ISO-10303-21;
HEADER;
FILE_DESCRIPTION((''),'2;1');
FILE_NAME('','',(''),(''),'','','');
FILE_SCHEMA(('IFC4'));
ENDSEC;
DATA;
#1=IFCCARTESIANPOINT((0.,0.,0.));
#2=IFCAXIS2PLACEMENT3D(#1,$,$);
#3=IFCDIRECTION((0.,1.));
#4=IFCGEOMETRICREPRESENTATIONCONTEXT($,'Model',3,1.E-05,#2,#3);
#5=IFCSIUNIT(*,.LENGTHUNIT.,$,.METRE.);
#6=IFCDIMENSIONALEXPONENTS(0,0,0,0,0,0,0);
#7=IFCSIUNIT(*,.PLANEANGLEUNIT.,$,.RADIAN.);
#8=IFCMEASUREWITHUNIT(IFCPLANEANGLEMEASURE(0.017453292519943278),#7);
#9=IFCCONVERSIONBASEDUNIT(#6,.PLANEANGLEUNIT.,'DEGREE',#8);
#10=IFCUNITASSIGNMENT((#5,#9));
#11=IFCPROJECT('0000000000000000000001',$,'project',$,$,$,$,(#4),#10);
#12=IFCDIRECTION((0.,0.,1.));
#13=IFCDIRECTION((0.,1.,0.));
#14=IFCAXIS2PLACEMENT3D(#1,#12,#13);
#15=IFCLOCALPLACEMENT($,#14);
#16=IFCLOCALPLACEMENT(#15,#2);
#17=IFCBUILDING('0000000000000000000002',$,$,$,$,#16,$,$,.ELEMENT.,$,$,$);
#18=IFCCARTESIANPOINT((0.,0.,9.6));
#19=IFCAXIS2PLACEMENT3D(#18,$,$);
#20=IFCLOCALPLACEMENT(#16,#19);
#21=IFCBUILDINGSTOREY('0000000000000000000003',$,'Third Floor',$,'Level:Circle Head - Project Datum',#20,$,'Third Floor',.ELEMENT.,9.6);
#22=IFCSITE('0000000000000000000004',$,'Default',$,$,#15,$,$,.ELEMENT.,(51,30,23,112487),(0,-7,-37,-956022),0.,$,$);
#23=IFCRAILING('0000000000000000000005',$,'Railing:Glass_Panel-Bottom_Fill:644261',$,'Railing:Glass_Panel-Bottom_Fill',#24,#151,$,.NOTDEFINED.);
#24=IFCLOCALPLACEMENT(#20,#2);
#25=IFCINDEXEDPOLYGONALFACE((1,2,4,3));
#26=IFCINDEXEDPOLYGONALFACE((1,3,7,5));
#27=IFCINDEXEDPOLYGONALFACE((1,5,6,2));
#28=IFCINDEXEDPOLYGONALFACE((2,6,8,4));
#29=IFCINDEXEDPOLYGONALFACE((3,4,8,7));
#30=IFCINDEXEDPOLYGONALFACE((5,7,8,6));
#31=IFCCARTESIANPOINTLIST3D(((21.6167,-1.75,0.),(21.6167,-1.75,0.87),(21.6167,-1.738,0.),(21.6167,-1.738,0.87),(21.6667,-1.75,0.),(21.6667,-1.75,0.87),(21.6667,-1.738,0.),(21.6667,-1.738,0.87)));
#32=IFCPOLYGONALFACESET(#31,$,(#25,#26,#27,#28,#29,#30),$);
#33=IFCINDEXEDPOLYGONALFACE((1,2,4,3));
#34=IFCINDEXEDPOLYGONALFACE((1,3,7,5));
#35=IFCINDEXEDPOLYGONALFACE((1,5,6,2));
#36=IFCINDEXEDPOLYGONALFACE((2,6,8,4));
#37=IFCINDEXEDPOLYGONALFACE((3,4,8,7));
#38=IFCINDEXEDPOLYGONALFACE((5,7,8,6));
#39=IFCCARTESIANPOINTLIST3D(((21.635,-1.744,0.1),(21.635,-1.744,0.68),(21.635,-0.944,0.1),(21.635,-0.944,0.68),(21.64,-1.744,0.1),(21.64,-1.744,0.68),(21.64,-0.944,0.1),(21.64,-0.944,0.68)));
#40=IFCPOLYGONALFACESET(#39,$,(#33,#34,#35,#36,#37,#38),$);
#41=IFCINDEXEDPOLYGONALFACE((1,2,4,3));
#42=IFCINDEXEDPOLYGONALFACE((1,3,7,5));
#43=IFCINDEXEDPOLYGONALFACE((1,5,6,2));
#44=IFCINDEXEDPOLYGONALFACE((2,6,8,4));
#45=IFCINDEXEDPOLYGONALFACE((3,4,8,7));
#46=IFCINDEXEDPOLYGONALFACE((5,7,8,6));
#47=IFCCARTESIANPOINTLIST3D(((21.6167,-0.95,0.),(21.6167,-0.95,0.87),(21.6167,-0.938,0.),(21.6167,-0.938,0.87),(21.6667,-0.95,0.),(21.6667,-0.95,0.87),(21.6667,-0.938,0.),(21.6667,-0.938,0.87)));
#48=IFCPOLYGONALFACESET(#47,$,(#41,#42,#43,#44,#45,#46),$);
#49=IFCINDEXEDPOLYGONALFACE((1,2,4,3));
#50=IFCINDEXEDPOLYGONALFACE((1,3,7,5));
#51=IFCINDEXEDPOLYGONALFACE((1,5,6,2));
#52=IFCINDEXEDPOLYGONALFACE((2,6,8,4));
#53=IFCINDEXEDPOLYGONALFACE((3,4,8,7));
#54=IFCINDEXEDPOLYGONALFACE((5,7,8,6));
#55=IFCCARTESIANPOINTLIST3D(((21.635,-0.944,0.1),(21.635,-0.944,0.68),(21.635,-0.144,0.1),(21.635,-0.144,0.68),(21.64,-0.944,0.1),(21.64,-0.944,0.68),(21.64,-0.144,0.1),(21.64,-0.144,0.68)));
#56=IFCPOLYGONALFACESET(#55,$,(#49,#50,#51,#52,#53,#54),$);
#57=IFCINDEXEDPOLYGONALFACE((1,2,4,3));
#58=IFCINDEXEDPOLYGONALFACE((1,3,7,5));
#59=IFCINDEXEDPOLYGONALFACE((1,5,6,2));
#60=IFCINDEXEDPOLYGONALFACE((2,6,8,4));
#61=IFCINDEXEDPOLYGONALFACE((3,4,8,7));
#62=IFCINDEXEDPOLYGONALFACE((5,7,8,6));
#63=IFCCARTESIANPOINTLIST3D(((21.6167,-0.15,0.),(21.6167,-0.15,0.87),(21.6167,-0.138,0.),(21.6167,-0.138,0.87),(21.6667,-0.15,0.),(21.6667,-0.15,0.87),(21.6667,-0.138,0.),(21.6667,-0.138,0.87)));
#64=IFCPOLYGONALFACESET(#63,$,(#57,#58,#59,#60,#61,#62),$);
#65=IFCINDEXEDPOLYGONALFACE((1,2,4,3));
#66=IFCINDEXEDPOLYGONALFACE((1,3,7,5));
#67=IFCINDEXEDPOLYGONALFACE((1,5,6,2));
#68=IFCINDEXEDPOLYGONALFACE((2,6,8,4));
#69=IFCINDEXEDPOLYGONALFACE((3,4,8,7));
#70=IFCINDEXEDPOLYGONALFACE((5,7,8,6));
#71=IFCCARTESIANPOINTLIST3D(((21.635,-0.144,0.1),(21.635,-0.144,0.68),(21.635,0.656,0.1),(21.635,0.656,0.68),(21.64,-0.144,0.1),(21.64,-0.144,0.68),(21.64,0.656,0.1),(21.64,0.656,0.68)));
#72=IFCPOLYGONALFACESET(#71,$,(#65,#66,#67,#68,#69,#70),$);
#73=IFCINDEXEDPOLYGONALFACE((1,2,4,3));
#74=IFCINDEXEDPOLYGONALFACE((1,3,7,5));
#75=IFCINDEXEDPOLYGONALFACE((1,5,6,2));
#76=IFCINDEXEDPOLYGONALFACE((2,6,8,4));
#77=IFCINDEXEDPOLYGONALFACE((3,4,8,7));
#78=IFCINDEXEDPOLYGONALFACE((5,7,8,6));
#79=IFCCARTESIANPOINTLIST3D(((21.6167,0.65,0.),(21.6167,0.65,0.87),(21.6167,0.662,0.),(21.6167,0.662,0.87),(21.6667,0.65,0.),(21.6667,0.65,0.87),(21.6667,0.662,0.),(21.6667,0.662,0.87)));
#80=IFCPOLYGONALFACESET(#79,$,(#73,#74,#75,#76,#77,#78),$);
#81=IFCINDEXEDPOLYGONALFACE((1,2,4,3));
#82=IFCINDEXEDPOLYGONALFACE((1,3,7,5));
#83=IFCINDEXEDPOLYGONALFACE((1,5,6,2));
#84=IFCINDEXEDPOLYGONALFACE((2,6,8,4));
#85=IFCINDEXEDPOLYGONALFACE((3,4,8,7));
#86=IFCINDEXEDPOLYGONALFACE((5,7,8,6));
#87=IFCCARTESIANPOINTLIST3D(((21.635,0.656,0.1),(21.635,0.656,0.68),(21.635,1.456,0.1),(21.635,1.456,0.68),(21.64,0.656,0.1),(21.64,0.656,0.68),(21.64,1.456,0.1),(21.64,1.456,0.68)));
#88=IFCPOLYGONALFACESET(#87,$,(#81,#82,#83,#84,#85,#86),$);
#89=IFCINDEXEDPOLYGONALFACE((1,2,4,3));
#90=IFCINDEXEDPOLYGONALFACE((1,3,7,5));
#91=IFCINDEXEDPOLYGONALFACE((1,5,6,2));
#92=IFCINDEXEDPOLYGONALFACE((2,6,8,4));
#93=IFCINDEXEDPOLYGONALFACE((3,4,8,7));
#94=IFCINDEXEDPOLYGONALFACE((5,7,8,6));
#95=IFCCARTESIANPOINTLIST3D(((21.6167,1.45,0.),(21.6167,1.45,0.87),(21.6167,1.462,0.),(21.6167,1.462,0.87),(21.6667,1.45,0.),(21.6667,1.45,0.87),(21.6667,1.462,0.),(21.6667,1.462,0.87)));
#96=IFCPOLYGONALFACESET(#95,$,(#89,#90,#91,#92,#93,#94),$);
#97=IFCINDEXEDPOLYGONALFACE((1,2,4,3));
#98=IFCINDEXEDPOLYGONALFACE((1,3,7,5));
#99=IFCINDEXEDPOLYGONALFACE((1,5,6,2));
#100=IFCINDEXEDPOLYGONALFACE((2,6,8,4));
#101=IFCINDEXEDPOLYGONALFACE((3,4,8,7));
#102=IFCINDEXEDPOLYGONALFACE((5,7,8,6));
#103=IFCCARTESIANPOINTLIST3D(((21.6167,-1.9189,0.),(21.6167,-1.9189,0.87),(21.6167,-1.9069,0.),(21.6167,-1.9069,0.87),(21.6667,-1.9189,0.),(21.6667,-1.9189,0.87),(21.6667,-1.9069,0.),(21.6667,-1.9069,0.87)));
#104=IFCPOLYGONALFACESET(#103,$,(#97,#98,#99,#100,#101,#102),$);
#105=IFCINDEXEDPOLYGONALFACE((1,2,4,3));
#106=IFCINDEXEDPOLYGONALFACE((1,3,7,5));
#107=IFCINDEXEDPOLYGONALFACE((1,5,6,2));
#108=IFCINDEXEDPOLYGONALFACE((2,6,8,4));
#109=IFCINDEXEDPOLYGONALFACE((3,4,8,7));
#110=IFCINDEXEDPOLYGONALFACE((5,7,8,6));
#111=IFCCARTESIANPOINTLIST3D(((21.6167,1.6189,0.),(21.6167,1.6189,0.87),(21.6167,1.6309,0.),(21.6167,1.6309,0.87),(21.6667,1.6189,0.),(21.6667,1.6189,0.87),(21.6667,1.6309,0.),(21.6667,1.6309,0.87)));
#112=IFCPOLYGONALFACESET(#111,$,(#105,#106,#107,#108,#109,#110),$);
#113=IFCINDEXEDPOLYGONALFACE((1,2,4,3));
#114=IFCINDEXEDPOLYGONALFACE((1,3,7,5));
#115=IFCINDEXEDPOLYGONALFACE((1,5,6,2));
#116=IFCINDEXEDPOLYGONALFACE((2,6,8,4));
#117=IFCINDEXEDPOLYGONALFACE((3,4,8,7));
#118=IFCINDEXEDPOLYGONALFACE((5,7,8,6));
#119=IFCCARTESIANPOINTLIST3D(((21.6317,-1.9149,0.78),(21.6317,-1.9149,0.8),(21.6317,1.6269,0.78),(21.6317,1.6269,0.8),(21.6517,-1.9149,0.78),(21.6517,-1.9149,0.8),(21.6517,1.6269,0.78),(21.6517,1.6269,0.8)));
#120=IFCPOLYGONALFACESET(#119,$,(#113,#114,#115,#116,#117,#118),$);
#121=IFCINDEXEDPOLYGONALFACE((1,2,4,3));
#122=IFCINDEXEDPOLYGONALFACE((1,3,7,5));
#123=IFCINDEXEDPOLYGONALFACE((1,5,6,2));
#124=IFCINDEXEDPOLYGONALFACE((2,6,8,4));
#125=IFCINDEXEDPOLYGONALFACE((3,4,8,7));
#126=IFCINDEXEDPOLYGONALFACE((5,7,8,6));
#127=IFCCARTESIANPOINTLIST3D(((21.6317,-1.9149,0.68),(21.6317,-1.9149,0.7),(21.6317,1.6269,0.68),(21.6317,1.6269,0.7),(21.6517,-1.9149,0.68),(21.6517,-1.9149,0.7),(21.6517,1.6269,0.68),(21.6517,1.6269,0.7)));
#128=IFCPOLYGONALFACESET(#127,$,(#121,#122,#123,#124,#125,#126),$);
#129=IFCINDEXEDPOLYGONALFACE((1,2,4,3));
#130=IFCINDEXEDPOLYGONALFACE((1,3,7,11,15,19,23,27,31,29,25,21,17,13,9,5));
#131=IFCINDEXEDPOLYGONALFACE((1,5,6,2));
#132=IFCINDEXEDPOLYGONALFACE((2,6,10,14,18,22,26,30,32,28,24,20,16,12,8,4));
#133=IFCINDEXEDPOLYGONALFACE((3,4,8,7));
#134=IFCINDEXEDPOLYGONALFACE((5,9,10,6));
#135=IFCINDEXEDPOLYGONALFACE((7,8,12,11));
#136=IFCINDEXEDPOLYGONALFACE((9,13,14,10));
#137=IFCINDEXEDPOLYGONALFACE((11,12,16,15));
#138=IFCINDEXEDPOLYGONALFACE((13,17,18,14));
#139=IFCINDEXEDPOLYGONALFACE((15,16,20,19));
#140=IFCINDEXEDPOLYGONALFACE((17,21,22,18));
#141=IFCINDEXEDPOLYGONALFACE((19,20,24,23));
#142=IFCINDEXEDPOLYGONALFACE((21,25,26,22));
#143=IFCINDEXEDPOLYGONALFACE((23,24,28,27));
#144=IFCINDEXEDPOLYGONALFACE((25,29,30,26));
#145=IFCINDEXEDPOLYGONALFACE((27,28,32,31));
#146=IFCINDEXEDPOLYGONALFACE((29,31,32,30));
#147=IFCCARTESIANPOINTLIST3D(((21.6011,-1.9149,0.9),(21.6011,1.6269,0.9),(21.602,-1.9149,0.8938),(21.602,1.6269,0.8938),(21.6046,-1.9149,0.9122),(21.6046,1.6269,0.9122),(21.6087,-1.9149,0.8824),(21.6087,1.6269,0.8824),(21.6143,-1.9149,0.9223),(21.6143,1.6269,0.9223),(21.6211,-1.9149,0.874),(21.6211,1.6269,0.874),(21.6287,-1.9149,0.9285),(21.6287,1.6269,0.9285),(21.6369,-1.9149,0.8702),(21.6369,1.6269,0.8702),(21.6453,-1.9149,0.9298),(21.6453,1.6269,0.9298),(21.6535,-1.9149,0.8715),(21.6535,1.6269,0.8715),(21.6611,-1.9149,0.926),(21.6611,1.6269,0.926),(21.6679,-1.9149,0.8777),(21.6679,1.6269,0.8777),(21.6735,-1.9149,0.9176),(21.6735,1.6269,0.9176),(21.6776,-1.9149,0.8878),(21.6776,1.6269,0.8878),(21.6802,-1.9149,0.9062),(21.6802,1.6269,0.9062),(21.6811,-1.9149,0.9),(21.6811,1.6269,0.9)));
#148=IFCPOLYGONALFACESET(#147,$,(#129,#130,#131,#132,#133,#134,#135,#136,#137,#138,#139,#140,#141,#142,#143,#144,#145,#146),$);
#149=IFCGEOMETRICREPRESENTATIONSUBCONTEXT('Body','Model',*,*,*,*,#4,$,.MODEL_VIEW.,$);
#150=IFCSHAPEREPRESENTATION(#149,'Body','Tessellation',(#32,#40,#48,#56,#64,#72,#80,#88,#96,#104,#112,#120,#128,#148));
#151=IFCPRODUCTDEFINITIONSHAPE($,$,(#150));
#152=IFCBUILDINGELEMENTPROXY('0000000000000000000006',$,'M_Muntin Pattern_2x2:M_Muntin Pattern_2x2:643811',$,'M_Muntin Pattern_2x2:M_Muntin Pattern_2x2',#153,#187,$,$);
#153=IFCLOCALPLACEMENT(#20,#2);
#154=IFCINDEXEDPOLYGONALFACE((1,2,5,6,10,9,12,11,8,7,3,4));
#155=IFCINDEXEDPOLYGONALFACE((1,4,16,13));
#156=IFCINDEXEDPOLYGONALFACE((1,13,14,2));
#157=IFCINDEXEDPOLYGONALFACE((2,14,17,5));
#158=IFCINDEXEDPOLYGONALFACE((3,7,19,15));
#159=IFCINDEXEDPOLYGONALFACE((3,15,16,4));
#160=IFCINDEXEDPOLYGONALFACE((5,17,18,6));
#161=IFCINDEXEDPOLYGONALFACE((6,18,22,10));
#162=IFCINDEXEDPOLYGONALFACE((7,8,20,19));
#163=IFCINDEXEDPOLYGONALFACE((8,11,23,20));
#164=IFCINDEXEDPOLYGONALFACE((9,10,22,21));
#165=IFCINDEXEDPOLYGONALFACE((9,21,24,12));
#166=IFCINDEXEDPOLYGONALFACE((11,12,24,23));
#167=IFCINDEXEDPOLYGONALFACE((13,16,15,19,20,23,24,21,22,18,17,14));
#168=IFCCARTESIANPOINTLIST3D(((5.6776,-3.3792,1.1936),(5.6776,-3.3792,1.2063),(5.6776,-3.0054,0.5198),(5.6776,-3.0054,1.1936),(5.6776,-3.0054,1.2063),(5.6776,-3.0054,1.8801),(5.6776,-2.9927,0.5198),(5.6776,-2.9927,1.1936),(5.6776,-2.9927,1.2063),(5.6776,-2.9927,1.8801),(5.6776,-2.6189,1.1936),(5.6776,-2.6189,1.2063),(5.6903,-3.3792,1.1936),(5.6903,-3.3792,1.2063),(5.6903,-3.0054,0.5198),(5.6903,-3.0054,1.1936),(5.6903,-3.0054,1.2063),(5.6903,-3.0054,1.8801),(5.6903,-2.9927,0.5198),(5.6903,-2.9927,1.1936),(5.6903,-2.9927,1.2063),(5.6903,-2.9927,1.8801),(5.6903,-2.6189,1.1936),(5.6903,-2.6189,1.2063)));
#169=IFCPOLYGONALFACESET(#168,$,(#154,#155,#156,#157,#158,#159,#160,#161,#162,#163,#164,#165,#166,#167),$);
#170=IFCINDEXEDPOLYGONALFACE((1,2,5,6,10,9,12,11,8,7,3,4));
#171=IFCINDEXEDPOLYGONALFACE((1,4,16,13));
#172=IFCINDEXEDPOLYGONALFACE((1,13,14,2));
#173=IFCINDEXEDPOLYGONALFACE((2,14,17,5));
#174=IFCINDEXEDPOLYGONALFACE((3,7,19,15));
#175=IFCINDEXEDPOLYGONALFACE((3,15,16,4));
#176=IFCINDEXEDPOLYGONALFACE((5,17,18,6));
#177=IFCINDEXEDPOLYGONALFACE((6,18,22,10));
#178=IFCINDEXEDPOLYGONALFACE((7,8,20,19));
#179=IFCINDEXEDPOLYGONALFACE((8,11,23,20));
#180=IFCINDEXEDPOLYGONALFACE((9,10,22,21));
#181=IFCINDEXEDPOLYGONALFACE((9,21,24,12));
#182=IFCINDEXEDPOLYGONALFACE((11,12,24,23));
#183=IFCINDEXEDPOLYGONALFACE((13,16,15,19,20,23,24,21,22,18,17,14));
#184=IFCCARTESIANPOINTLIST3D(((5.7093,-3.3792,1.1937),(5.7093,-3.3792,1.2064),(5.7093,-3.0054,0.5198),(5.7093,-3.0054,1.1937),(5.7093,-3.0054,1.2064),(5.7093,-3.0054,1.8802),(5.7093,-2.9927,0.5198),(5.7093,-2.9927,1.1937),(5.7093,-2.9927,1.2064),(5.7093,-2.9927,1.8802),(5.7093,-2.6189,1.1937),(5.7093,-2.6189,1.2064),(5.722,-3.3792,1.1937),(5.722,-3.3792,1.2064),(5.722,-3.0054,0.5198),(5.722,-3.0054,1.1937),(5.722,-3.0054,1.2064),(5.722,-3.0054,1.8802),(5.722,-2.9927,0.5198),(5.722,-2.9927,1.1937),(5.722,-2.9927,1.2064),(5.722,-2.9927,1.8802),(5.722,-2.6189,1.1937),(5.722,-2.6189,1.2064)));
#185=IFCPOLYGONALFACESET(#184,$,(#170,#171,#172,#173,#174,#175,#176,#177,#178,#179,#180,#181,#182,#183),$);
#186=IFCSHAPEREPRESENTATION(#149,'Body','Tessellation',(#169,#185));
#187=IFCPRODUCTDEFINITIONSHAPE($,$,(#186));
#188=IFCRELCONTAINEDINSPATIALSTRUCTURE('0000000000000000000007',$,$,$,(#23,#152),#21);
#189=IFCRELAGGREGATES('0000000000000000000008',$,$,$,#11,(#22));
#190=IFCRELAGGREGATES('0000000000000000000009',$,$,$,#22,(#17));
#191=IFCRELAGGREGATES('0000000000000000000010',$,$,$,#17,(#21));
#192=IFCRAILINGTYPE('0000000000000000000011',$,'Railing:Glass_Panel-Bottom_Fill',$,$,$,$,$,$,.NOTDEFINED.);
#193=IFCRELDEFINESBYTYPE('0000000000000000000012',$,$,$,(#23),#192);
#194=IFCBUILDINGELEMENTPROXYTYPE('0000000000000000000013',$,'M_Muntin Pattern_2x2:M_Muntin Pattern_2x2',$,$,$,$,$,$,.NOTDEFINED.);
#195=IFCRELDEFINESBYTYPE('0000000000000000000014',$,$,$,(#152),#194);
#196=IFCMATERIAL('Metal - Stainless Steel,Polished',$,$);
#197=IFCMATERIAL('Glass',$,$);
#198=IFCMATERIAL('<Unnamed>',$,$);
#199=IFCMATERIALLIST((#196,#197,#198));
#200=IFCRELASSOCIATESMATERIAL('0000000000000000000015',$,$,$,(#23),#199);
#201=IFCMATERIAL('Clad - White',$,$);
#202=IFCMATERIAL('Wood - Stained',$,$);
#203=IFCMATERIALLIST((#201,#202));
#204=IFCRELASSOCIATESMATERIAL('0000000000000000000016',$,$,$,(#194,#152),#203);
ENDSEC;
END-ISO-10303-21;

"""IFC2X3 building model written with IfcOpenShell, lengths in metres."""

from ifc_helpers import new_model, entity, si_unit, converted_unit, direction, frame, frame_2d, origin, origin_2d_with_axis, place, context, subcontext, project, spatial, polyline, rectangle, outline, extrude, source, transform, mapped, material, material_list, type_object, type_shapes, element, save


model = new_model("IFC2X3")

# Units and contexts
model_context = context("Model", 3, precision=1e-05, world=origin(), true_north=direction((0.0, 1.0)))
body_context = subcontext(model_context, "Body", "Model", "MODEL_VIEW")
ifc_project = project(units=[si_unit("LENGTHUNIT", "METRE"), converted_unit("PLANEANGLEUNIT", "DEGREE", entity("IfcPlaneAngleMeasure", 0.017453292519943278), si_unit("PLANEANGLEUNIT", "RADIAN"), dimensions=[0, 0, 0, 0, 0, 0, 0])], contexts=[model_context])

# Site, building, storey
site_placement = place(None, frame((0.0, 0.0, 0.0), z_axis=(0.0, 0.0, 1.0), x_axis=(0.0, 1.0, 0.0)))
site = spatial("IfcSite", under=ifc_project, at=site_placement, Name="Default", CompositionType="ELEMENT", RefLatitude=(51, 30, 23, 112487), RefLongitude=(0, -7, -37, -956022), RefElevation=0.0)
building_placement = place(site_placement, origin())
building = spatial("IfcBuilding", under=site, at=building_placement, CompositionType="ELEMENT")
storey_placement = place(building_placement, frame((0.0, 0.0, 9.6)))
storey = spatial("IfcBuildingStorey", under=building, at=storey_placement, Name="Third Floor", ObjectType="Level:Circle Head - Project Datum", LongName="Third Floor", CompositionType="ELEMENT", Elevation=9.6)

# Railing
ifc_material_1 = material(Name="Metal - Stainless Steel,Polished")
ifc_material_2 = material(Name="Glass")
ifc_material_3 = material(Name="<Unnamed>")
ifc_material_list_1 = material_list([ifc_material_1, ifc_material_2, ifc_material_3])
railing_type = type_object("IfcRailingType", Name="Railing:Glass_Panel-Bottom_Fill", PredefinedType="NOTDEFINED")
railing_placement = place(storey_placement, origin())
element("IfcRailing", 1, at=railing_placement, inside=storey, type_object=railing_type, material=ifc_material_list_1, Name="Railing:Glass_Panel-Bottom_Fill:644261", ObjectType="Railing:Glass_Panel-Bottom_Fill", PredefinedType="NOTDEFINED", context=body_context, shape_type="SweptSolid", body=[
    extrude(rectangle(XDim=0.05, YDim=0.012, at=origin_2d_with_axis()), frame((21.6417, -1.744, 0.0), z_axis=(0.0, 0.0, 1.0), x_axis=(-1.0, 0.0, 0.0)), (0.0, 0.0, 1.0), 0.87),
    extrude(rectangle(XDim=0.005, YDim=0.8, at=frame_2d((0.0, 0.0), x_axis=(1.0, 0.0))), frame((21.6375, -1.344, 0.1), z_axis=(0.0, 0.0, 1.0), x_axis=(-1.0, 0.0, 0.0)), (0.0, 0.0, 1.0), 0.58),
    extrude(rectangle(XDim=0.05, YDim=0.012, at=origin_2d_with_axis()), frame((21.6417, -0.944, 0.0), z_axis=(0.0, 0.0, 1.0), x_axis=(-1.0, 0.0, 0.0)), (0.0, 0.0, 1.0), 0.87),
    extrude(rectangle(XDim=0.005, YDim=0.8, at=frame_2d((0.0, 0.0), x_axis=(1.0, 0.0))), frame((21.6375, -0.544, 0.1), z_axis=(0.0, 0.0, 1.0), x_axis=(-1.0, 0.0, 0.0)), (0.0, 0.0, 1.0), 0.58),
    extrude(rectangle(XDim=0.05, YDim=0.012, at=frame_2d((0.0, 0.0), x_axis=(1.0, 0.0))), frame((21.6417, -0.144, 0.0), z_axis=(0.0, 0.0, 1.0), x_axis=(-1.0, 0.0, 0.0)), (0.0, 0.0, 1.0), 0.87),
    extrude(rectangle(XDim=0.005, YDim=0.8, at=frame_2d((0.0, 0.0), x_axis=(1.0, 0.0))), frame((21.6375, 0.256, 0.1), z_axis=(0.0, 0.0, 1.0), x_axis=(-1.0, 0.0, 0.0)), (0.0, 0.0, 1.0), 0.58),
    extrude(rectangle(XDim=0.05, YDim=0.012, at=frame_2d((0.0, 0.0), x_axis=(1.0, 0.0))), frame((21.6417, 0.656, 0.0), z_axis=(0.0, 0.0, 1.0), x_axis=(-1.0, 0.0, 0.0)), (0.0, 0.0, 1.0), 0.87),
    extrude(rectangle(XDim=0.005, YDim=0.8, at=frame_2d((0.0, 0.0), x_axis=(1.0, 0.0))), frame((21.6375, 1.056, 0.1), z_axis=(0.0, 0.0, 1.0), x_axis=(-1.0, 0.0, 0.0)), (0.0, 0.0, 1.0), 0.58),
    extrude(rectangle(XDim=0.05, YDim=0.012, at=frame_2d((0.0, 0.0), x_axis=(1.0, 0.0))), frame((21.6417, 1.456, 0.0), z_axis=(0.0, 0.0, 1.0), x_axis=(-1.0, 0.0, 0.0)), (0.0, 0.0, 1.0), 0.87),
    extrude(rectangle(XDim=0.05, YDim=0.012, at=origin_2d_with_axis()), frame((21.6417, -1.9129, 0.0), z_axis=(0.0, 0.0, 1.0), x_axis=(-1.0, 0.0, 0.0)), (0.0, 0.0, 1.0), 0.87),
    extrude(rectangle(XDim=0.05, YDim=0.012, at=frame_2d((0.0, 0.0), x_axis=(1.0, 0.0))), frame((21.6417, 1.6249, 0.0), z_axis=(0.0, 0.0, 1.0), x_axis=(-1.0, 0.0, 0.0)), (0.0, 0.0, 1.0), 0.87),
    extrude(rectangle(XDim=3.5418, YDim=0.02, at=origin_2d_with_axis()), frame((21.6417, -0.144, 0.78), z_axis=(0.0, 0.0, 1.0), x_axis=(0.0, -1.0, 0.0)), (0.0, 0.0, 1.0), 0.02),
    extrude(rectangle(XDim=3.5418, YDim=0.02, at=origin_2d_with_axis()), frame((21.6417, -0.144, 0.68), z_axis=(0.0, 0.0, 1.0), x_axis=(0.0, -1.0, 0.0)), (0.0, 0.0, 1.0), 0.02),
    extrude(outline(polyline([(-0.0109, -0.0385), (0.0018, -0.0385), (0.0142, -0.0318), (0.0241, -0.0197), (0.0298, -0.0041), (0.0304, 0.0122), (0.0258, 0.0263), (0.0167, 0.0359), (0.0109, 0.0385), (-0.0018, 0.0385), (-0.0142, 0.0318), (-0.0241, 0.0197), (-0.0298, 0.0041), (-0.0304, -0.0122), (-0.0258, -0.0263), (-0.0167, -0.0359), (-0.0109, -0.0385)])), frame((21.6411, -1.9149, 0.9), z_axis=(0.0, 1.0, 0.0), x_axis=(-0.27267, 0.0, -0.962108)), (0.0, 0.0, 1.0), 3.5418),
])

# Building element proxy
ifc_material_4 = material(Name="Clad - White")
ifc_material_5 = material(Name="Wood - Stained")
ifc_material_list_2 = material_list([ifc_material_4, ifc_material_5])
building_element_proxy_type_1 = type_object("IfcBuildingElementProxyType", Name="M_Muntin Pattern_2x2:M_Muntin Pattern_2x2", PredefinedType="NOTDEFINED", material=ifc_material_list_2)
shared_shape_1 = source(origin(), body_context, "Body", "SweptSolid", [
    extrude(outline(polyline([(0.0064, -0.0064), (0.6801, -0.0064), (0.6801, 0.0063), (0.0064, 0.0063), (0.0064, 0.3802), (-0.0063, 0.3802), (-0.0063, 0.0063), (-0.6802, 0.0063), (-0.6802, -0.0064), (-0.0063, -0.0064), (-0.0063, -0.3801), (0.0064, -0.3801), (0.0064, -0.0064)])), frame((0.0, 0.0095, 0.6801), z_axis=(0.0, 1.0, 0.0), x_axis=(0.0, 0.0, 1.0)), (0.0, 0.0, 1.0), 0.0127),
    extrude(outline(polyline([(0.0064, -0.0064), (0.6802, -0.0064), (0.6802, 0.0063), (0.0064, 0.0063), (0.0064, 0.3802), (-0.0063, 0.3802), (-0.0063, 0.0063), (-0.6802, 0.0063), (-0.6802, -0.0064), (-0.0063, -0.0064), (-0.0063, -0.3801), (0.0064, -0.3801), (0.0064, -0.0064)])), frame((0.0, -0.0222, 0.6802), z_axis=(0.0, 1.0, 0.0), x_axis=(0.0, 0.0, 1.0)), (0.0, 0.0, 1.0), 0.0127),
])
type_shapes(building_element_proxy_type_1, [shared_shape_1])
for number, where, z_axis, x_axis, name in (
    (2, (5.6998, -2.9991, 0.5198), (0.0, 0.0, 1.0), (0.0, 1.0, 0.0), "M_Muntin Pattern_2x2:M_Muntin Pattern_2x2:643811"),
):
    element("IfcBuildingElementProxy", number, at=place(storey_placement, frame(where, z_axis=z_axis, x_axis=x_axis)), inside=storey, type_object=building_element_proxy_type_1, material=ifc_material_list_2, Name=name, ObjectType="M_Muntin Pattern_2x2:M_Muntin Pattern_2x2", context=body_context, shape_type="MappedRepresentation", body=[
        mapped(shared_shape_1, transform((0.0, 0.0, 0.0), scale=1.0)),
    ])

save(model, "model.ifc")
